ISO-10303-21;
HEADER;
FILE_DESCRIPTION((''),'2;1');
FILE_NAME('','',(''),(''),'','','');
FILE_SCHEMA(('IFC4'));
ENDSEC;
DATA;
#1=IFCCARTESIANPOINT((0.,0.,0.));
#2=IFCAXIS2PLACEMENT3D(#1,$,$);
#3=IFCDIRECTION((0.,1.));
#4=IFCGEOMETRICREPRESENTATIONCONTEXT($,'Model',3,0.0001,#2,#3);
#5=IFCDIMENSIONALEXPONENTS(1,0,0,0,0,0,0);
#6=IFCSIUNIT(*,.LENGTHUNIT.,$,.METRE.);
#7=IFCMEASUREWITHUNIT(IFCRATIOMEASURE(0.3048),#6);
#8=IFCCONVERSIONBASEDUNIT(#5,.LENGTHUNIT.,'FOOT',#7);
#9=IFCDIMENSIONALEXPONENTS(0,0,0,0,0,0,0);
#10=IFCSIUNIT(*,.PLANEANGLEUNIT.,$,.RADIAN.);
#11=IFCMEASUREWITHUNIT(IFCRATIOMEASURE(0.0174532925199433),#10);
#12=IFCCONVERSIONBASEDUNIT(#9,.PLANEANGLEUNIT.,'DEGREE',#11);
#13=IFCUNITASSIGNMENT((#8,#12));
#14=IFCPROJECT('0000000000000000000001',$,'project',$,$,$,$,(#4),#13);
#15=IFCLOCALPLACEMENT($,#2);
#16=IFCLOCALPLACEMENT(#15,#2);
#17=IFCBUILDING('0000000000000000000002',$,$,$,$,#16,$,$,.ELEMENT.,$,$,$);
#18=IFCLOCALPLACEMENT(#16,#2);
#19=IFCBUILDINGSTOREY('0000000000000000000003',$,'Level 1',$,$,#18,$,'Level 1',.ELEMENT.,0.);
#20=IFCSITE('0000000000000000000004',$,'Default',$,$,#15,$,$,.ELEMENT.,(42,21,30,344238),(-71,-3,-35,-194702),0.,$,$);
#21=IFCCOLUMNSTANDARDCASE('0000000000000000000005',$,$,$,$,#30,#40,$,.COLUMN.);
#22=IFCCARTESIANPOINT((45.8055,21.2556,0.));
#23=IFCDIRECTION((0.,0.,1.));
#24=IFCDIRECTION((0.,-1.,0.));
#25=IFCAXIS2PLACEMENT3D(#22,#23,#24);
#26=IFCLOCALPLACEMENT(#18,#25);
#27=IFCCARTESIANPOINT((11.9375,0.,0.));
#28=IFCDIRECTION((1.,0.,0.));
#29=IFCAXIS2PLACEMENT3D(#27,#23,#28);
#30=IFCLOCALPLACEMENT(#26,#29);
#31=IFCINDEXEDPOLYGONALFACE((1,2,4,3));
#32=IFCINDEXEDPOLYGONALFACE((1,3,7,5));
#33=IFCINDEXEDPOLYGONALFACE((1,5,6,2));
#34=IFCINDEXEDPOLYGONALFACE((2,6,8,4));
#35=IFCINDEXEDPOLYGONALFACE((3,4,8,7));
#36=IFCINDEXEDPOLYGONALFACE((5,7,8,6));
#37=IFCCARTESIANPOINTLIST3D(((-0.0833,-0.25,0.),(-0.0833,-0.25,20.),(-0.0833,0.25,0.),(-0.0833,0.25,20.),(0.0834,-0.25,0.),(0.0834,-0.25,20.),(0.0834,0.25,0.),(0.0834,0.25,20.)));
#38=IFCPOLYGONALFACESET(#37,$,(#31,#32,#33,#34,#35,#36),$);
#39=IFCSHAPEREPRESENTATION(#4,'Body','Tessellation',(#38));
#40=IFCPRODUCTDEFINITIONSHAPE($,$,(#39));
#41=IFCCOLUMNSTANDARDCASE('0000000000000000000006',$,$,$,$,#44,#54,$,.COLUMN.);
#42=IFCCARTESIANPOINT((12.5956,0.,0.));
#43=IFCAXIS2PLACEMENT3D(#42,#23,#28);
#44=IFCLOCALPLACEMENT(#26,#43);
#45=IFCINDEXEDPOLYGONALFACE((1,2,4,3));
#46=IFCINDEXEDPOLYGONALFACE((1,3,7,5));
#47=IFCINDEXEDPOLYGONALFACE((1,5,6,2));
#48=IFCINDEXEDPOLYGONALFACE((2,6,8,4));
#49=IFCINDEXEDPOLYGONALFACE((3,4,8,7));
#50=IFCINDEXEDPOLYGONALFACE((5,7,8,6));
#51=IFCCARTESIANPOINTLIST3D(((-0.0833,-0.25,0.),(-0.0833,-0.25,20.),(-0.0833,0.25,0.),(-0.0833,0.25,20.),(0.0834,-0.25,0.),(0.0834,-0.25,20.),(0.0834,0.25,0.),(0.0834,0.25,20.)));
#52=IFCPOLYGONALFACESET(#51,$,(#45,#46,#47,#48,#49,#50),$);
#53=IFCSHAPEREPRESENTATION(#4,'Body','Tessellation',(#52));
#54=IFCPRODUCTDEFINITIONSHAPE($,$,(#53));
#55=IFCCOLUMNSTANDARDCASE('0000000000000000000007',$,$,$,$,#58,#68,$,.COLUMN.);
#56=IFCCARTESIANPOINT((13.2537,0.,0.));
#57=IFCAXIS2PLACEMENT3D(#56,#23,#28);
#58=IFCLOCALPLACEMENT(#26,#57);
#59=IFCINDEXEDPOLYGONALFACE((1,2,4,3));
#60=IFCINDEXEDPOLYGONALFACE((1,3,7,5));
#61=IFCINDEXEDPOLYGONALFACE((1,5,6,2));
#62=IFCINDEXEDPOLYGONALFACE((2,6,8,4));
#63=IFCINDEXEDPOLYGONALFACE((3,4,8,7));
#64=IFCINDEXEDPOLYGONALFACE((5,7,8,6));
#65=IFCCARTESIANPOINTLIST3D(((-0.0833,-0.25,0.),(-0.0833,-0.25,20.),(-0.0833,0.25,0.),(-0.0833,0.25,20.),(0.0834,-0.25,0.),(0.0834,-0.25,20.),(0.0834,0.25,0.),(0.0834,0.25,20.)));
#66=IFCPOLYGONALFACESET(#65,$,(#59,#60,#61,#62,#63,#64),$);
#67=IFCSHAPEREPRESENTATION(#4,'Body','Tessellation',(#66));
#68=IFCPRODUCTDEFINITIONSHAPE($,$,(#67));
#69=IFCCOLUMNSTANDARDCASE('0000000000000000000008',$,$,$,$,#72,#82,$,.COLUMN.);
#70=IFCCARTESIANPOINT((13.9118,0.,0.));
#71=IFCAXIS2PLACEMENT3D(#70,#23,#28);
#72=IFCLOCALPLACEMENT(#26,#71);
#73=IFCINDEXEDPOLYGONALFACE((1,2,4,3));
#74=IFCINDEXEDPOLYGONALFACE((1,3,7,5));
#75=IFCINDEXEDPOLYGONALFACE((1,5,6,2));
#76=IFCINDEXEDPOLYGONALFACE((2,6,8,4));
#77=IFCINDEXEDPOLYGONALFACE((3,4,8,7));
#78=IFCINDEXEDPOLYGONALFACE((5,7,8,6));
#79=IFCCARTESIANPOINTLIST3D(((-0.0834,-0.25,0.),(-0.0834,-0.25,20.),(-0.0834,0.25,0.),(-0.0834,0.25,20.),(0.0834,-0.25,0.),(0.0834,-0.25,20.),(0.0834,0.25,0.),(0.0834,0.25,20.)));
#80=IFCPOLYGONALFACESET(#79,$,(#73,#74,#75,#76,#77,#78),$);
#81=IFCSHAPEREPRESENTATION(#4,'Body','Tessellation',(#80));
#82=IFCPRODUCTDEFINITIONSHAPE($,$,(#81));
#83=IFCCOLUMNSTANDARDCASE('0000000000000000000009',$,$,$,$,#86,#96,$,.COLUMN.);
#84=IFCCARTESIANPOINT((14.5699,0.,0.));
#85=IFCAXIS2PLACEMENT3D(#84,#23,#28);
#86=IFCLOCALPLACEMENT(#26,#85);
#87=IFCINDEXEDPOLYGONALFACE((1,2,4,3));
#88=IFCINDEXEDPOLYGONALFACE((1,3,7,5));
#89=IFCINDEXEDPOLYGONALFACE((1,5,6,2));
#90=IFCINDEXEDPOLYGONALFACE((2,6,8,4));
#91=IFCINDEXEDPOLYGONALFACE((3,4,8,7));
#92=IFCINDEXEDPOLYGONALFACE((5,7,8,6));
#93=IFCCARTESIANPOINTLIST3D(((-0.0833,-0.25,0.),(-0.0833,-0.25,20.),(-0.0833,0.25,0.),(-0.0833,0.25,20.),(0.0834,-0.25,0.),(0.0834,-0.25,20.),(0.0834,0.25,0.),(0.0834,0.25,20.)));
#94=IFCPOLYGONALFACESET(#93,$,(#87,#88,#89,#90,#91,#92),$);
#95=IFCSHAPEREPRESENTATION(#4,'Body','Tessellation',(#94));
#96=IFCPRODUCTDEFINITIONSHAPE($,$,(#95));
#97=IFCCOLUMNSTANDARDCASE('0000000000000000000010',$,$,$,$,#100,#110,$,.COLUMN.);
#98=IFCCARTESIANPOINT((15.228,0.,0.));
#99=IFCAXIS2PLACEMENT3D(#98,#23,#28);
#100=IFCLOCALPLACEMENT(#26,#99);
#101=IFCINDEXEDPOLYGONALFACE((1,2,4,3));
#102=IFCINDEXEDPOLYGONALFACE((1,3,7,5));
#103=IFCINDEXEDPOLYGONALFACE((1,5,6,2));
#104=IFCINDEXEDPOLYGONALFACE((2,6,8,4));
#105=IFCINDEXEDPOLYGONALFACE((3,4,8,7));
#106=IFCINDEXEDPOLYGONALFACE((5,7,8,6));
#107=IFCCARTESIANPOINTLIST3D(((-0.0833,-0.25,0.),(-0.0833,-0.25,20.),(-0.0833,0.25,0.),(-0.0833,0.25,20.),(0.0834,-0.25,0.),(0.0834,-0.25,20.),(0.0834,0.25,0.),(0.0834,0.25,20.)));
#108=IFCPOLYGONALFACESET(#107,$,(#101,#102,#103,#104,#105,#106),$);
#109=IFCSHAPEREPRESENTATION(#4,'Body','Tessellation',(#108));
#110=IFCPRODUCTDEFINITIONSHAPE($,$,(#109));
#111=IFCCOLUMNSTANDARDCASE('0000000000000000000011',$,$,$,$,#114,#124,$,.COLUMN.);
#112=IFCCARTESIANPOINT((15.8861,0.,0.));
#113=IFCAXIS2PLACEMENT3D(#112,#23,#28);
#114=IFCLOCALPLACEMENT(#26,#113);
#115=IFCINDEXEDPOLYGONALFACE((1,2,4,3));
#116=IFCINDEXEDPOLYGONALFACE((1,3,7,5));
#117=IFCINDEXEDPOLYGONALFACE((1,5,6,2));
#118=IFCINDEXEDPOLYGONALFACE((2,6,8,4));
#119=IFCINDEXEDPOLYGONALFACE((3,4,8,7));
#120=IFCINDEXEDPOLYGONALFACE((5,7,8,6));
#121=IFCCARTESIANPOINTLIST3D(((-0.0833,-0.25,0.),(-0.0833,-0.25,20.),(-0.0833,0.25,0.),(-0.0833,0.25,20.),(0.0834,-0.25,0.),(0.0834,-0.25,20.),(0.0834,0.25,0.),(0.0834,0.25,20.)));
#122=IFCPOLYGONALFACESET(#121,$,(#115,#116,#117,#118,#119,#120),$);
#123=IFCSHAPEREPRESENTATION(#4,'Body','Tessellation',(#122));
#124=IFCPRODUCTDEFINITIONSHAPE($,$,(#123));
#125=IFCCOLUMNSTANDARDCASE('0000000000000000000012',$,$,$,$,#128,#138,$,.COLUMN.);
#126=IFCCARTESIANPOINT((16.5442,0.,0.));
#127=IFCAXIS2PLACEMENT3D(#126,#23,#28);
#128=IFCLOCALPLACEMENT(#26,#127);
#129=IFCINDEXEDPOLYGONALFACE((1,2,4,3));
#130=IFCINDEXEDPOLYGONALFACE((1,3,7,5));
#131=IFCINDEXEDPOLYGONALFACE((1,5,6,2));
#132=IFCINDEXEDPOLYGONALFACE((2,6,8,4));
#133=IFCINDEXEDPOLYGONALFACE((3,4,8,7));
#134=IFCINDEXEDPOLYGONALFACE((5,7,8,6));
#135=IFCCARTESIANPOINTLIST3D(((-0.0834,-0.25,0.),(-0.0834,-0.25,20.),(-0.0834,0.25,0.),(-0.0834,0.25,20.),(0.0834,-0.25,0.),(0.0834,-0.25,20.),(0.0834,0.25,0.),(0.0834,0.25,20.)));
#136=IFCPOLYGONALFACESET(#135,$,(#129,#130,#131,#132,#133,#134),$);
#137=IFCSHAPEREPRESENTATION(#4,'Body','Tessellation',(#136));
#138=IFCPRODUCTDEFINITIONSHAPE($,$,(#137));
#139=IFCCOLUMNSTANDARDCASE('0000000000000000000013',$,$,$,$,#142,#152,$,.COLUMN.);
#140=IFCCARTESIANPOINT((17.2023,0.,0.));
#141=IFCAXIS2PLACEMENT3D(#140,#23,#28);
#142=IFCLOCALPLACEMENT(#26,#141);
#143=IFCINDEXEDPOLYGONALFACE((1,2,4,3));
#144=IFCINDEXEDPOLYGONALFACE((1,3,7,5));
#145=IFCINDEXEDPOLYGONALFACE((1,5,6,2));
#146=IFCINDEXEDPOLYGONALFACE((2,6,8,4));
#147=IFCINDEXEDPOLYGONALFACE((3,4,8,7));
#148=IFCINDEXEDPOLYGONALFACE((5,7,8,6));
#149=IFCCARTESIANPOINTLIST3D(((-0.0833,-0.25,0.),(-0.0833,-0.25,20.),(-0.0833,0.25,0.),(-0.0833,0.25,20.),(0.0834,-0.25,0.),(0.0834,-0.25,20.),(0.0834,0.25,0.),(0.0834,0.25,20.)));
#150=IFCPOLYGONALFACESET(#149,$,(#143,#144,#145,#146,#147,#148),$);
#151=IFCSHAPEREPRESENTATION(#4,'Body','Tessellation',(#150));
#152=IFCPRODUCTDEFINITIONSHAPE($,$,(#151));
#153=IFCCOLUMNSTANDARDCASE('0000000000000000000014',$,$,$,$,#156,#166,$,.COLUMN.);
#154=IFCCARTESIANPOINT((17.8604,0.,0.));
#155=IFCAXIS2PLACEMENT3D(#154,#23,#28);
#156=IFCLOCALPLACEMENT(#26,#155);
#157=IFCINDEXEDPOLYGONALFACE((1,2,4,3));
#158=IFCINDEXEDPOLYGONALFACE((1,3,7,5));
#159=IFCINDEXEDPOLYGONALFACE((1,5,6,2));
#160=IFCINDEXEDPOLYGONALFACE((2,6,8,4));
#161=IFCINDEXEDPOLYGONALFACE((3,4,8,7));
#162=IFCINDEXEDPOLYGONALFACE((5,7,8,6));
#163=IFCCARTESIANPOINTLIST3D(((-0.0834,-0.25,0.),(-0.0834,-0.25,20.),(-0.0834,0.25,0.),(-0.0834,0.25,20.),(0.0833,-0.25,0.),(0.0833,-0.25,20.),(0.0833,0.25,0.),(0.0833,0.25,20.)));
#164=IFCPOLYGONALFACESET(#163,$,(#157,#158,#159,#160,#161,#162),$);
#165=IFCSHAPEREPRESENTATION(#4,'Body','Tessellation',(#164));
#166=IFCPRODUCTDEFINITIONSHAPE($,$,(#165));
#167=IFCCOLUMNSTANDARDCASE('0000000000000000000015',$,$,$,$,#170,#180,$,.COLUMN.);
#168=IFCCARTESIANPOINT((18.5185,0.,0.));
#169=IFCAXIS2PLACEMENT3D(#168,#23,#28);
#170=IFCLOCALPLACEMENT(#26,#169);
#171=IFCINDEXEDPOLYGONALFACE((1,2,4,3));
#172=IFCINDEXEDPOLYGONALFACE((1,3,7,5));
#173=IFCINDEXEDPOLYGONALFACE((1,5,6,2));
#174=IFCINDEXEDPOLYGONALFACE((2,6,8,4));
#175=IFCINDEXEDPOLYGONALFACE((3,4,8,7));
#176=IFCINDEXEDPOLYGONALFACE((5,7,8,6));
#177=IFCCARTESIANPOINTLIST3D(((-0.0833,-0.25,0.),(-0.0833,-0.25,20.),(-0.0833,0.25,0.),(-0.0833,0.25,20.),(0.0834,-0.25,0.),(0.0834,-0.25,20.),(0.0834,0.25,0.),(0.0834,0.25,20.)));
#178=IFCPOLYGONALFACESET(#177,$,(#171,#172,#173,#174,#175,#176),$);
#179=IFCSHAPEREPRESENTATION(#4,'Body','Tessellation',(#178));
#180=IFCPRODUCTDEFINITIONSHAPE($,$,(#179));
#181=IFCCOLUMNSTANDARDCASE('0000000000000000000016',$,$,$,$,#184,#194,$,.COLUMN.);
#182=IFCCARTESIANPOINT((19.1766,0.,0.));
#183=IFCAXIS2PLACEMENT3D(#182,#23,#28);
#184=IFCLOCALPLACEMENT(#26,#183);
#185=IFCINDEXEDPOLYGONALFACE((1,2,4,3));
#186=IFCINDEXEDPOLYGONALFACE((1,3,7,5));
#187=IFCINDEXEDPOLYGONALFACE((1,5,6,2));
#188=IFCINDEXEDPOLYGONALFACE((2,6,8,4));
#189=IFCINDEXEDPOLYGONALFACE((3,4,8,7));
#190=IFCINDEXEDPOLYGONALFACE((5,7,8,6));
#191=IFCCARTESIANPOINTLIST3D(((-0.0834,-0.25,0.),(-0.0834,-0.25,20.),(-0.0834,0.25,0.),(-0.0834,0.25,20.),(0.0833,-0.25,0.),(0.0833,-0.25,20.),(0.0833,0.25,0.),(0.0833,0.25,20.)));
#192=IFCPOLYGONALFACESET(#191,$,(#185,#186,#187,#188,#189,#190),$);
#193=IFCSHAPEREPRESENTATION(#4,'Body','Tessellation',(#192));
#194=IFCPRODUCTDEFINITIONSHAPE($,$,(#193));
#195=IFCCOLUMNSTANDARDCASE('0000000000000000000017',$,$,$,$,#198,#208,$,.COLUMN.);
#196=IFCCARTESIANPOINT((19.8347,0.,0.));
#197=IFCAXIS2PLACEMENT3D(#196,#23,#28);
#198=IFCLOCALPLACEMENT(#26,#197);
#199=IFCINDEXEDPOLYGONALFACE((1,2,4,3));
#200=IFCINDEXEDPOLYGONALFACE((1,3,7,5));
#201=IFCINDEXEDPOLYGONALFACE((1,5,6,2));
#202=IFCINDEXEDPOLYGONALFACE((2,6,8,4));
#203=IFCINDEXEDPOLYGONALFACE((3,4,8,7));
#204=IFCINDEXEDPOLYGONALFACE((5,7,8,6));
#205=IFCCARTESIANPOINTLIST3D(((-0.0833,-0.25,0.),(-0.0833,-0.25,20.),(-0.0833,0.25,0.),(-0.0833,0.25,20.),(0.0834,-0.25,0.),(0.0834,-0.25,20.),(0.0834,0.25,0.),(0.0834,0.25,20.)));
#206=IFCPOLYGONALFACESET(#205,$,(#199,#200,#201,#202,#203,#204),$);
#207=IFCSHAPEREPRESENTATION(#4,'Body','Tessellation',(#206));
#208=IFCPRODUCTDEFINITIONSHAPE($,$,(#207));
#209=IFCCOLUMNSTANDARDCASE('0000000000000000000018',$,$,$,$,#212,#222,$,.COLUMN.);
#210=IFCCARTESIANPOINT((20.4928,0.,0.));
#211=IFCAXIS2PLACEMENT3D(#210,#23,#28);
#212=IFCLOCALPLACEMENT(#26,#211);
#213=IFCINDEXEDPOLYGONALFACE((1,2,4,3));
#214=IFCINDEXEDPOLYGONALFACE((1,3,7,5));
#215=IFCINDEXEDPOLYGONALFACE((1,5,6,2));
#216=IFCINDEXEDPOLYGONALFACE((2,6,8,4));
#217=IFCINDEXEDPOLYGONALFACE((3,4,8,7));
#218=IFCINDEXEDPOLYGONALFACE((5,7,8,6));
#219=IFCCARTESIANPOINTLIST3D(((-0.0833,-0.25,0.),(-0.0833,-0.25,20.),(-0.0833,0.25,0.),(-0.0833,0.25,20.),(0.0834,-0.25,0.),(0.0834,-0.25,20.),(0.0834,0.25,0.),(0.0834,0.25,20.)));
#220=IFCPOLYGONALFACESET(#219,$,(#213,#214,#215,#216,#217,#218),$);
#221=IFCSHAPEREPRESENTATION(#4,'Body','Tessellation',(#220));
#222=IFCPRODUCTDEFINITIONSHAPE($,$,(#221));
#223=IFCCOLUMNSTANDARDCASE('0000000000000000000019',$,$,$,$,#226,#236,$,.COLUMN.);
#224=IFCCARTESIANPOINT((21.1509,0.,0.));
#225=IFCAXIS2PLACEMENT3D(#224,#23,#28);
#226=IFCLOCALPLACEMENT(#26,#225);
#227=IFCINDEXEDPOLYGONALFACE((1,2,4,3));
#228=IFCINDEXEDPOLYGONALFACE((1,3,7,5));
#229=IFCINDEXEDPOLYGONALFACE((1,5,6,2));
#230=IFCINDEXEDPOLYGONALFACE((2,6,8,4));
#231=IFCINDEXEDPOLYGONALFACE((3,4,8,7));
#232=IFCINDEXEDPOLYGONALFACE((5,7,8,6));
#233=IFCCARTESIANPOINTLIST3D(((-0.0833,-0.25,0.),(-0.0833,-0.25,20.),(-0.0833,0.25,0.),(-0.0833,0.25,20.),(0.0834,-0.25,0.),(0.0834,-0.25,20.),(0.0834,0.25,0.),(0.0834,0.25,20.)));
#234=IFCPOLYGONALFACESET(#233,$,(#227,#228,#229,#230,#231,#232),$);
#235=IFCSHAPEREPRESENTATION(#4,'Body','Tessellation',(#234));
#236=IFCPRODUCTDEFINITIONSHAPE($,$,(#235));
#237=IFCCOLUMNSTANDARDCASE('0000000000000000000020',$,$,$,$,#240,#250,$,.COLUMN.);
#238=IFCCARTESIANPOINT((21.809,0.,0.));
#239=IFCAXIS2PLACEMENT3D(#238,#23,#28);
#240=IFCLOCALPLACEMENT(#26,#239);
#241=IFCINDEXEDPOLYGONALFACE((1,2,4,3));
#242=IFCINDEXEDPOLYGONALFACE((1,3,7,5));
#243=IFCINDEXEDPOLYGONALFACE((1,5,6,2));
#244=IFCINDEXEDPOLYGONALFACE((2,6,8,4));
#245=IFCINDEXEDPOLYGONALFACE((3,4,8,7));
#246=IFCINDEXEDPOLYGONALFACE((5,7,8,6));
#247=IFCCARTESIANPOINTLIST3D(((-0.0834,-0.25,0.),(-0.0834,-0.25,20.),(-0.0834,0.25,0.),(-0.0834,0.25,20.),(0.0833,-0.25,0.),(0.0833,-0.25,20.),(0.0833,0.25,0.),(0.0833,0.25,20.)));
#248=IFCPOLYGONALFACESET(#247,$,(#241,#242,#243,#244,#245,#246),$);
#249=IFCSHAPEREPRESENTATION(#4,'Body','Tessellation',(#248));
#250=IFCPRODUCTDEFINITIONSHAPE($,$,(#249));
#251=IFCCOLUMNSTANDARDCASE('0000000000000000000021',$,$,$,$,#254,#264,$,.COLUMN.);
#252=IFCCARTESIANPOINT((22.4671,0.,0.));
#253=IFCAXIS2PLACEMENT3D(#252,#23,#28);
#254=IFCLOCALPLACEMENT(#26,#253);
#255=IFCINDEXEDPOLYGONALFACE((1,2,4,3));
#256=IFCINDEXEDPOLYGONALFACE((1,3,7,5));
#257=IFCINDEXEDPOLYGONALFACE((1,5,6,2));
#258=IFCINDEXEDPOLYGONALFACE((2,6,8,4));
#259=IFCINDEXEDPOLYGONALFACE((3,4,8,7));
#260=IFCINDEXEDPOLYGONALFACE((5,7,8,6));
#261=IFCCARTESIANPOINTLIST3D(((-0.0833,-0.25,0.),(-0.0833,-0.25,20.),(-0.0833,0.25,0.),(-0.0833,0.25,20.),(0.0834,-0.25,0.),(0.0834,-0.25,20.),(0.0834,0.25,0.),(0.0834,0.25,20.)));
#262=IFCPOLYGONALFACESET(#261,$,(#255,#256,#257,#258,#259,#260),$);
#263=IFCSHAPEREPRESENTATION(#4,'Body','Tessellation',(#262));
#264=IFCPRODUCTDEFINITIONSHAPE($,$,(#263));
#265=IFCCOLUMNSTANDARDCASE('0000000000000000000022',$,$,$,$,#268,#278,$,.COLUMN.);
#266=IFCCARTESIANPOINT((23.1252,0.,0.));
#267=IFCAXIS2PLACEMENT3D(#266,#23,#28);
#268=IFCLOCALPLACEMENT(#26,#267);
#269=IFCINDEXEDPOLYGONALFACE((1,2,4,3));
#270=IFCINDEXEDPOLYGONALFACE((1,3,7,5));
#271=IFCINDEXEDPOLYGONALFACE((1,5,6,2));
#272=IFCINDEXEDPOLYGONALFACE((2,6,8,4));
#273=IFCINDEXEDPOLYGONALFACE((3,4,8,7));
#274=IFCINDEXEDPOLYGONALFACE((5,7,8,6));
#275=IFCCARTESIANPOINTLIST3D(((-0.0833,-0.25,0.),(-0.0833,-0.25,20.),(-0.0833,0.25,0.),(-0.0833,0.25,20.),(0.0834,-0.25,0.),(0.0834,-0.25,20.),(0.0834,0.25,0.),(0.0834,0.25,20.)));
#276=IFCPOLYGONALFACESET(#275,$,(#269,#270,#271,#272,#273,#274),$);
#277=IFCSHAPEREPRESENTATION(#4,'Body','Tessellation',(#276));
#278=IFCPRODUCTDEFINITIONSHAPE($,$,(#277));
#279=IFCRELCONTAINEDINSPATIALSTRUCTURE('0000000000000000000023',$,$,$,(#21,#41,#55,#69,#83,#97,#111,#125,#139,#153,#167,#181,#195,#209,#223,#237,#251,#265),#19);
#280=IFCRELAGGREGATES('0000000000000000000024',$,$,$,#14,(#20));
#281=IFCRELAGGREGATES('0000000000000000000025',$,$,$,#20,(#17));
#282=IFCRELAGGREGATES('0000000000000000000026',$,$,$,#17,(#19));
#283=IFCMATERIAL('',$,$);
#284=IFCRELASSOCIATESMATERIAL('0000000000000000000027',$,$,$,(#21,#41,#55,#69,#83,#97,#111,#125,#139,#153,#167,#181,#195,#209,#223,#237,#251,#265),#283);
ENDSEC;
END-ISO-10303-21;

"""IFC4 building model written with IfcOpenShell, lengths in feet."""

from ifc_helpers import new_model, entity, si_unit, converted_unit, direction, frame, origin, place, context, project, spatial, rectangle, extrude, material, element, save


model = new_model("IFC4")

# Units and contexts
model_context = context("Model", 3, precision=0.0001, world=origin(), true_north=direction((0.0, 1.0)))
ifc_project = project(units=[converted_unit("LENGTHUNIT", "FOOT", entity("IfcRatioMeasure", 0.3048), si_unit("LENGTHUNIT", "METRE"), dimensions=[1, 0, 0, 0, 0, 0, 0]), converted_unit("PLANEANGLEUNIT", "DEGREE", entity("IfcRatioMeasure", 0.0174532925199433), si_unit("PLANEANGLEUNIT", "RADIAN"), dimensions=[0, 0, 0, 0, 0, 0, 0])], contexts=[model_context])

# Site, building, storey
site_placement = place(None, origin())
site = spatial("IfcSite", under=ifc_project, at=site_placement, Name="Default", CompositionType="ELEMENT", RefLatitude=(42, 21, 30, 344238), RefLongitude=(-71, -3, -35, -194702), RefElevation=0.0)
building_placement = place(site_placement, origin())
building = spatial("IfcBuilding", under=site, at=building_placement, CompositionType="ELEMENT")
storey_placement = place(building_placement, origin())
storey = spatial("IfcBuildingStorey", under=building, at=storey_placement, Name="Level 1", LongName="Level 1", CompositionType="ELEMENT", Elevation=0.0)

# Columns
ifc_material_1 = material(Name="")
placement = place(storey_placement, frame((45.8055, 21.2556, 0.0), z_axis=(0.0, 0.0, 1.0), x_axis=(0.0, -1.0, 0.0)))
for number, where, z_axis, x_axis in (
    (1, (11.9375, 0.0, 0.0), (0.0, 0.0, 1.0), (1.0, 0.0, 0.0)),
    (2, (12.5956, 0.0, 0.0), (0.0, 0.0, 1.0), (1.0, 0.0, 0.0)),
    (3, (13.2537, 0.0, 0.0), (0.0, 0.0, 1.0), (1.0, 0.0, 0.0)),
    (4, (13.9118, 0.0, 0.0), (0.0, 0.0, 1.0), (1.0, 0.0, 0.0)),
    (5, (14.5699, 0.0, 0.0), (0.0, 0.0, 1.0), (1.0, 0.0, 0.0)),
    (6, (15.228, 0.0, 0.0), (0.0, 0.0, 1.0), (1.0, 0.0, 0.0)),
    (7, (15.8861, 0.0, 0.0), (0.0, 0.0, 1.0), (1.0, 0.0, 0.0)),
    (8, (16.5442, 0.0, 0.0), (0.0, 0.0, 1.0), (1.0, 0.0, 0.0)),
    (9, (17.2023, 0.0, 0.0), (0.0, 0.0, 1.0), (1.0, 0.0, 0.0)),
    (10, (17.8604, 0.0, 0.0), (0.0, 0.0, 1.0), (1.0, 0.0, 0.0)),
    (11, (18.5185, 0.0, 0.0), (0.0, 0.0, 1.0), (1.0, 0.0, 0.0)),
    (12, (19.1766, 0.0, 0.0), (0.0, 0.0, 1.0), (1.0, 0.0, 0.0)),
    (13, (19.8347, 0.0, 0.0), (0.0, 0.0, 1.0), (1.0, 0.0, 0.0)),
    (14, (20.4928, 0.0, 0.0), (0.0, 0.0, 1.0), (1.0, 0.0, 0.0)),
    (15, (21.1509, 0.0, 0.0), (0.0, 0.0, 1.0), (1.0, 0.0, 0.0)),
    (16, (21.809, 0.0, 0.0), (0.0, 0.0, 1.0), (1.0, 0.0, 0.0)),
    (17, (22.4671, 0.0, 0.0), (0.0, 0.0, 1.0), (1.0, 0.0, 0.0)),
    (18, (23.1252, 0.0, 0.0), (0.0, 0.0, 1.0), (1.0, 0.0, 0.0)),
):
    element("IfcColumnStandardCase", number, at=place(placement, frame(where, z_axis=z_axis, x_axis=x_axis)), inside=storey, material=ifc_material_1, PredefinedType="COLUMN", context=model_context, shape_type="SweptSolid", body=[
        extrude(rectangle(XDim=0.1667, YDim=0.5), origin(), (0.0, 0.0, 1.0), 20.0),
    ])

save(model, "model.ifc")
